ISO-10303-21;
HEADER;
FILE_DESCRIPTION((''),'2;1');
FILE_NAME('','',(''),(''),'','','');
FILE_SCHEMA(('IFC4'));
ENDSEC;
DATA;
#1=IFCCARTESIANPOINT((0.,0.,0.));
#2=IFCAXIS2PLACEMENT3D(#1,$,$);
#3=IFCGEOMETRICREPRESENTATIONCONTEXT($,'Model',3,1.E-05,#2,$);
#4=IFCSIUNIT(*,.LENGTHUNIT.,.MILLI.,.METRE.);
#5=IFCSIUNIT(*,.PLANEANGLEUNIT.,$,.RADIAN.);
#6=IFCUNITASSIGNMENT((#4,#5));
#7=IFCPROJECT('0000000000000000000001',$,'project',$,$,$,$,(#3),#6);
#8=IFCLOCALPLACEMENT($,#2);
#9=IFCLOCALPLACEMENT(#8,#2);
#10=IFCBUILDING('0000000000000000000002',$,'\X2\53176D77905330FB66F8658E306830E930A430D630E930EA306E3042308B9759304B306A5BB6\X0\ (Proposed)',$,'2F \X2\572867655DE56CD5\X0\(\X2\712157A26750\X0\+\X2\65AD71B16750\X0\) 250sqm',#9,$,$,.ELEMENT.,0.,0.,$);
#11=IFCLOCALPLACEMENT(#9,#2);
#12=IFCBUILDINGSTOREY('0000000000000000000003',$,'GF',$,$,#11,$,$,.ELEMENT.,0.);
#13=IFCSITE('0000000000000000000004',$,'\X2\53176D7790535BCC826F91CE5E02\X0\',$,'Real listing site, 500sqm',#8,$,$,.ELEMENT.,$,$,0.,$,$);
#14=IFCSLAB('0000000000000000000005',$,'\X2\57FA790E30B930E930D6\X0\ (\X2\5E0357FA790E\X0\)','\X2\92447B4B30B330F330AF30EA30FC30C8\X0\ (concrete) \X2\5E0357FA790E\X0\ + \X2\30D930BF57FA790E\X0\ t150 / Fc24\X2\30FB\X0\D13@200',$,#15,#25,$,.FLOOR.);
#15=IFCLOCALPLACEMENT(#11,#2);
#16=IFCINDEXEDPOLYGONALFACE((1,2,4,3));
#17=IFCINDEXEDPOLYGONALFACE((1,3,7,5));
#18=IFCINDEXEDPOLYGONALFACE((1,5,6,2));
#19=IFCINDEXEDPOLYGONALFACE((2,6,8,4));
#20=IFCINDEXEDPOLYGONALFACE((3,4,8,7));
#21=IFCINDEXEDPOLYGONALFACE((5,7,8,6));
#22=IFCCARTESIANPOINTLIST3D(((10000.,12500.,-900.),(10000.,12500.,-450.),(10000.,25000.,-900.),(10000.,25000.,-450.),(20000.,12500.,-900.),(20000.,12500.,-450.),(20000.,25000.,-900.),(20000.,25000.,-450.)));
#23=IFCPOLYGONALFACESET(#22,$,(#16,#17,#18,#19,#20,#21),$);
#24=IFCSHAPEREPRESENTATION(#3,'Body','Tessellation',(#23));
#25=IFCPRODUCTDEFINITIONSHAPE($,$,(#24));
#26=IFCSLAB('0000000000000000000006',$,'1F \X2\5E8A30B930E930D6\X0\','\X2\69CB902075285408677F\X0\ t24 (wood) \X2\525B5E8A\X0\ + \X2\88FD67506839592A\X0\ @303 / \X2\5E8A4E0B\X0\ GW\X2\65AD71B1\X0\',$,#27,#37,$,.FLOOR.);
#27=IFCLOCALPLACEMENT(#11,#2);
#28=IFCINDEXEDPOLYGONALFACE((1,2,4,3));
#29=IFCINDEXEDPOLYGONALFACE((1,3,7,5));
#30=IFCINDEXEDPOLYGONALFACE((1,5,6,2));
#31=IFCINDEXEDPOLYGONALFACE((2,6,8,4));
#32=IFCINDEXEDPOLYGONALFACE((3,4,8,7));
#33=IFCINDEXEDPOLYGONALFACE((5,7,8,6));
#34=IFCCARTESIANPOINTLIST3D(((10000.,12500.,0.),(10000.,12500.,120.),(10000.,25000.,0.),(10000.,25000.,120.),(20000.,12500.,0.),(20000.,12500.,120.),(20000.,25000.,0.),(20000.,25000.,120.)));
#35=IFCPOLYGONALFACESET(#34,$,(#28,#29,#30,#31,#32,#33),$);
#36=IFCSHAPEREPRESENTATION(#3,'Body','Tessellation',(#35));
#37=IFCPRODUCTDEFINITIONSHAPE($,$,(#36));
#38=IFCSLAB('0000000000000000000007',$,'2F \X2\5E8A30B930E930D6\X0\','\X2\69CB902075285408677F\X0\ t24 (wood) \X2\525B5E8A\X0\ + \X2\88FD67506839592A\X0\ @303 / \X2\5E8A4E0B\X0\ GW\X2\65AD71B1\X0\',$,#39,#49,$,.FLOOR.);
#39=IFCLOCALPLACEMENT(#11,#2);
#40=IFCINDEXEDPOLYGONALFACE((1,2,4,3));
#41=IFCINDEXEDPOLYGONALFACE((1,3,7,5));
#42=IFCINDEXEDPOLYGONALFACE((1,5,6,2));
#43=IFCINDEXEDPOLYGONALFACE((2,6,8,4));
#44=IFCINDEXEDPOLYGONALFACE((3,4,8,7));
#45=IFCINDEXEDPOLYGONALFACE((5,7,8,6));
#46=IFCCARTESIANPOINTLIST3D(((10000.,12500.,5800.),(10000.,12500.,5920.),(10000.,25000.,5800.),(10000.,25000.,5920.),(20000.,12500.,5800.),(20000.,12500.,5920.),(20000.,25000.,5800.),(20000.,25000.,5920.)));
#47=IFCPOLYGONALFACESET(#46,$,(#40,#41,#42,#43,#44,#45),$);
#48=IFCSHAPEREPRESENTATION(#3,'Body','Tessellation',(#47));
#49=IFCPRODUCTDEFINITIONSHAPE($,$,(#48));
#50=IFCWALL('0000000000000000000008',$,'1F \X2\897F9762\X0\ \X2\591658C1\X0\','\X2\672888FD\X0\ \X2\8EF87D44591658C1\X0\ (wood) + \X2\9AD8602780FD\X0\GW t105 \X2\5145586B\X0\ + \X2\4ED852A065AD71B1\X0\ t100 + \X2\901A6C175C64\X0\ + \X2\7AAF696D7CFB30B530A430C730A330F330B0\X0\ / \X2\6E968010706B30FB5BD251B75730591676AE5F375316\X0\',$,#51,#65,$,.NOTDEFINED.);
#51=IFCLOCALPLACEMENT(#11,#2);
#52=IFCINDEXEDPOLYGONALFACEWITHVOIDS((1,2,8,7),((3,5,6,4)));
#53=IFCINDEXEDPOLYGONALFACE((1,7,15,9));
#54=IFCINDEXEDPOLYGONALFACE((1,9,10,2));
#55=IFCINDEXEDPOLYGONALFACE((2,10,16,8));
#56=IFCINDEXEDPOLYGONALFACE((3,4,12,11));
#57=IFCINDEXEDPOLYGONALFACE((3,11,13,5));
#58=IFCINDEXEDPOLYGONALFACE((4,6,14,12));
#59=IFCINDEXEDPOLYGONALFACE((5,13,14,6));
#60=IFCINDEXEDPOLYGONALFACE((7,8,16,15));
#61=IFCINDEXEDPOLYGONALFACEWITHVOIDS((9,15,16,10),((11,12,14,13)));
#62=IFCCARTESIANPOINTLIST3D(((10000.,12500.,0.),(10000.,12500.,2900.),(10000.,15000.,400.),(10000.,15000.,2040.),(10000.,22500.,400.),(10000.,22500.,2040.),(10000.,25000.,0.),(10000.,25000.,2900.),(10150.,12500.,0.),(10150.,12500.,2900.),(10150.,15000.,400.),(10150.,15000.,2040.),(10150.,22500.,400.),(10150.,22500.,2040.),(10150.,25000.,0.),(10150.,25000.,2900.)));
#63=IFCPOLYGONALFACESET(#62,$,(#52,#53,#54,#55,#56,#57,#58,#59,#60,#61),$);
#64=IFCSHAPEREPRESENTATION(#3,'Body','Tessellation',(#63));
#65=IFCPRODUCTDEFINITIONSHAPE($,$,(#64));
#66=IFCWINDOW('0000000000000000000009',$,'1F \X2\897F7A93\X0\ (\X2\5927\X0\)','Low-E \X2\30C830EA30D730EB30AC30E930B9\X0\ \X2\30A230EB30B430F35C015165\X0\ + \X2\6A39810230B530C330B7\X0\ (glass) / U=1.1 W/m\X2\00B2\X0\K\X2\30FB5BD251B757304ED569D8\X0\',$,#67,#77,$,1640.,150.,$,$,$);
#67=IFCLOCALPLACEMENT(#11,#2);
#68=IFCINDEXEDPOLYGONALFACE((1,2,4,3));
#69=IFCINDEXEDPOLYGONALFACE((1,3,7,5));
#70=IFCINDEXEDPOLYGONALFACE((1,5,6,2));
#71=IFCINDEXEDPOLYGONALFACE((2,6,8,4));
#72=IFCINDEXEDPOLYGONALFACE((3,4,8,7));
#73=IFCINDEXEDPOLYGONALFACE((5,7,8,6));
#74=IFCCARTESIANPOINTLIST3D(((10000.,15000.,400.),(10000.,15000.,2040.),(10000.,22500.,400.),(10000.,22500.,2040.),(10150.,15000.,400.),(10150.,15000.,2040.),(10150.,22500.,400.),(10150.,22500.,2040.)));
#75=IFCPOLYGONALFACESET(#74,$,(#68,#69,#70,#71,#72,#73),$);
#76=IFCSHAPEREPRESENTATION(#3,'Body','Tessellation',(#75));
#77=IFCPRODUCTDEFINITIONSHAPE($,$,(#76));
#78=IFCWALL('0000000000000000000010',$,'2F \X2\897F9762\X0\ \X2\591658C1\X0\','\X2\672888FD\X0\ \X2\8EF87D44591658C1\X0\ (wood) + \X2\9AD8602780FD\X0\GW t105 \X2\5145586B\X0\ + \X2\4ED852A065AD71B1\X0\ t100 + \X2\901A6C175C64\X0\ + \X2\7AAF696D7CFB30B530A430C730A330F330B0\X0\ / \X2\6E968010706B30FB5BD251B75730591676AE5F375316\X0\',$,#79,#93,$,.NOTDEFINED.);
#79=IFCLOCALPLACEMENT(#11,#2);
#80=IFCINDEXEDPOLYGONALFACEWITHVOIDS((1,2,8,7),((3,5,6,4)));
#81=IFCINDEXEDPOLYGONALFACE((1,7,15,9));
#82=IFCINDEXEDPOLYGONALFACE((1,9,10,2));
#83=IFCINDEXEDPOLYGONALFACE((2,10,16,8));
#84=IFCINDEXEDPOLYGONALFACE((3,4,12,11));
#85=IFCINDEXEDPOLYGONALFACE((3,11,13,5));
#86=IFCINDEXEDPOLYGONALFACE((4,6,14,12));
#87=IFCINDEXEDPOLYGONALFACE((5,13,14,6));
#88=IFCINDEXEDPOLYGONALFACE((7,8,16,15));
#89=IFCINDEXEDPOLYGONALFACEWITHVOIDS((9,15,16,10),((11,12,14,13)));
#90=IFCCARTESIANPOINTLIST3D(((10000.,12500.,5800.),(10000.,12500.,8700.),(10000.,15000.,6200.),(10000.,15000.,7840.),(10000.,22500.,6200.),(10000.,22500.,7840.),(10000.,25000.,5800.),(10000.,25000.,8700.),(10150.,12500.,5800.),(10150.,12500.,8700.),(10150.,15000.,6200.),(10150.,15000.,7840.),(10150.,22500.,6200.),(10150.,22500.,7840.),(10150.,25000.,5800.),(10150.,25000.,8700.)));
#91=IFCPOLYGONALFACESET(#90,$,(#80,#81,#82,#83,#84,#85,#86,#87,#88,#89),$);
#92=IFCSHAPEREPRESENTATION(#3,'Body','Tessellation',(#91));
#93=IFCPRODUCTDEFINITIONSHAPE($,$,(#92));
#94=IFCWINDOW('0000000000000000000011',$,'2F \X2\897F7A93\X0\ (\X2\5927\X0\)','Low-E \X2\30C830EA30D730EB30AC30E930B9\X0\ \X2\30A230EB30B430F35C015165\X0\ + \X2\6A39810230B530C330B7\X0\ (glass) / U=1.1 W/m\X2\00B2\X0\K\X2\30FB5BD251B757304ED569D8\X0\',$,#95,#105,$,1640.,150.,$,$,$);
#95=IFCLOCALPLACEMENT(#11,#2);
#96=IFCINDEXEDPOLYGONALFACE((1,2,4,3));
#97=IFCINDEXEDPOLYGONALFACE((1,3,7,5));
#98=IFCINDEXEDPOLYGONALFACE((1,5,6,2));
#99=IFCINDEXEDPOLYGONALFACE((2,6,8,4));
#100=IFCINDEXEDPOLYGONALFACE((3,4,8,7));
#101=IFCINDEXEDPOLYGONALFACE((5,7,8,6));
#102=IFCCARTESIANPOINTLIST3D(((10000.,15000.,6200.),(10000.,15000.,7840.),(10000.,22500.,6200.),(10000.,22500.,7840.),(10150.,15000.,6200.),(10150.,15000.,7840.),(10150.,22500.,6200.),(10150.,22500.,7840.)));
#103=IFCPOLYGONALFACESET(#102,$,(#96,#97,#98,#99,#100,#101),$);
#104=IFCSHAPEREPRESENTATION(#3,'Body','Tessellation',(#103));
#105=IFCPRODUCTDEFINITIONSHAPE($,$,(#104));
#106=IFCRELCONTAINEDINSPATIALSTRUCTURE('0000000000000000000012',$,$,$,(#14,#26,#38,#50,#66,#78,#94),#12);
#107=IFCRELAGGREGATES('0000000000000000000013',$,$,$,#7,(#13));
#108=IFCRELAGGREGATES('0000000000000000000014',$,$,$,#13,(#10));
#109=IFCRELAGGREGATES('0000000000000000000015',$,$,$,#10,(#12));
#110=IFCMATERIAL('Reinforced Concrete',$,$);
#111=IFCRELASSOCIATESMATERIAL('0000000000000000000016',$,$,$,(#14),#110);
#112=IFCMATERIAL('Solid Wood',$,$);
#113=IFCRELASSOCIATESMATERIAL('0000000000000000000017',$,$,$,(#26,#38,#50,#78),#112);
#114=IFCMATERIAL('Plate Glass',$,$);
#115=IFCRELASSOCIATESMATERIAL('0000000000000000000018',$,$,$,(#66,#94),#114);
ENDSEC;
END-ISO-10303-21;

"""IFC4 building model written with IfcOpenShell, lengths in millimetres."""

from ifc_helpers import new_model, si_unit, frame, frame_2d, origin, place, context, project, spatial, rectangle, extrude, material, element, fill, save


model = new_model("IFC4")

# Units and contexts
model_context = context("Model", 3, precision=1e-05, world=origin())
ifc_project = project(units=[si_unit("LENGTHUNIT", "METRE", prefix="MILLI"), si_unit("PLANEANGLEUNIT", "RADIAN")], contexts=[model_context])

# Site, building, storey
site_placement = place(None, origin())
site = spatial("IfcSite", under=ifc_project, at=site_placement, Name="北海道富良野市", ObjectType="Real listing site, 500sqm", CompositionType="ELEMENT", RefElevation=0.0)
building_placement = place(site_placement, origin())
building = spatial("IfcBuilding", under=site, at=building_placement, Name="北海道・書斎とライブラリのある静かな家 (Proposed)", ObjectType="2F 在来工法(無垢材+断熱材) 250sqm", CompositionType="ELEMENT", ElevationOfRefHeight=0.0, ElevationOfTerrain=0.0)
storey_placement = place(building_placement, origin())
storey = spatial("IfcBuildingStorey", under=building, at=storey_placement, Name="GF", CompositionType="ELEMENT", Elevation=0.0)

# Shared definitions
ifc_material_1 = material(Name="Solid Wood")

# Slabs
ifc_material_2 = material(Name="Reinforced Concrete")
slab_1_placement = place(storey_placement, frame((5000.0, 6250.0, -450.0)))
element("IfcSlab", 1, at=slab_1_placement, inside=storey, material=ifc_material_2, Name="基礎スラブ (布基礎)", Description="鉄筋コンクリート (concrete) 布基礎 + ベタ基礎 t150 / Fc24・D13@200", PredefinedType="FLOOR", context=model_context, shape_type="SweptSolid", body=[
    extrude(rectangle(XDim=10000.0, YDim=12500.0, at=frame_2d((5000.0, 6250.0))), frame((5000.0, 6250.0, -450.0)), (0.0, 0.0, 1.0), 450.0),
])
slab_2_placement = place(storey_placement, frame((5000.0, 6250.0, 0.0)))
element("IfcSlab", 2, at=slab_2_placement, inside=storey, material=ifc_material_1, Name="1F 床スラブ", Description="構造用合板 t24 (wood) 剛床 + 製材根太 @303 / 床下 GW断熱", PredefinedType="FLOOR", context=model_context, shape_type="SweptSolid", body=[
    extrude(rectangle(XDim=10000.0, YDim=12500.0, at=frame_2d((5000.0, 6250.0))), frame((5000.0, 6250.0, 0.0)), (0.0, 0.0, 1.0), 120.0),
])
slab_3_placement = place(storey_placement, frame((5000.0, 6250.0, 2900.0)))
element("IfcSlab", 3, at=slab_3_placement, inside=storey, material=ifc_material_1, Name="2F 床スラブ", Description="構造用合板 t24 (wood) 剛床 + 製材根太 @303 / 床下 GW断熱", PredefinedType="FLOOR", context=model_context, shape_type="SweptSolid", body=[
    extrude(rectangle(XDim=10000.0, YDim=12500.0, at=frame_2d((5000.0, 6250.0))), frame((5000.0, 6250.0, 2900.0)), (0.0, 0.0, 1.0), 120.0),
])

# Shared definitions
ifc_material_3 = material(Name="Plate Glass")

# Wall, opening, window
wall_1_placement = place(storey_placement, frame((5000.0, 6250.0, 0.0)))
wall_1 = element("IfcWall", 4, at=wall_1_placement, inside=storey, material=ifc_material_1, Name="1F 西面 外壁", Description="木製 軸組外壁 (wood) + 高性能GW t105 充填 + 付加断熱 t100 + 通気層 + 窯業系サイディング / 準耐火・寒冷地外皮強化", PredefinedType="NOTDEFINED", context=model_context, shape_type="SweptSolid", body=[
    extrude(rectangle(XDim=150.0, YDim=12500.0, at=frame_2d((75.0, 6250.0))), frame((5000.0, 6250.0, 0.0)), (0.0, 0.0, 1.0), 2900.0),
])
opening_1_placement = place(storey_placement, frame((5000.0, 7500.0, 200.0)))
opening_1 = element("IfcOpeningElement", 5, at=opening_1_placement, cuts=wall_1, PredefinedType="NOTDEFINED", context=model_context, shape_type="SweptSolid", body=[
    extrude(rectangle(XDim=150.0, YDim=7500.0, at=frame_2d((75.0, 3750.0))), frame((5000.0, 7500.0, 200.0)), (0.0, 0.0, 1.0), 1640.0),
])
window_1_placement = place(storey_placement, frame((5000.0, 7500.0, 200.0)))
window_1 = element("IfcWindow", 6, at=window_1_placement, inside=storey, material=ifc_material_3, Name="1F 西窓 (大)", Description="Low-E トリプルガラス アルゴン封入 + 樹脂サッシ (glass) / U=1.1 W/m²K・寒冷地仕様", OverallHeight=1640.0, OverallWidth=150.0, context=model_context, shape_type="SweptSolid", body=[
    extrude(rectangle(XDim=150.0, YDim=7500.0, at=frame_2d((75.0, 3750.0))), frame((5000.0, 7500.0, 200.0)), (0.0, 0.0, 1.0), 1640.0),
])
fill(opening_1, window_1)

# Wall, opening, window
wall_2_placement = place(storey_placement, frame((5000.0, 6250.0, 2900.0)))
wall_2 = element("IfcWall", 7, at=wall_2_placement, inside=storey, material=ifc_material_1, Name="2F 西面 外壁", Description="木製 軸組外壁 (wood) + 高性能GW t105 充填 + 付加断熱 t100 + 通気層 + 窯業系サイディング / 準耐火・寒冷地外皮強化", PredefinedType="NOTDEFINED", context=model_context, shape_type="SweptSolid", body=[
    extrude(rectangle(XDim=150.0, YDim=12500.0, at=frame_2d((75.0, 6250.0))), frame((5000.0, 6250.0, 2900.0)), (0.0, 0.0, 1.0), 2900.0),
])
opening_2_placement = place(storey_placement, frame((5000.0, 7500.0, 3100.0)))
opening_2 = element("IfcOpeningElement", 8, at=opening_2_placement, cuts=wall_2, PredefinedType="NOTDEFINED", context=model_context, shape_type="SweptSolid", body=[
    extrude(rectangle(XDim=150.0, YDim=7500.0, at=frame_2d((75.0, 3750.0))), frame((5000.0, 7500.0, 3100.0)), (0.0, 0.0, 1.0), 1640.0),
])
window_2_placement = place(storey_placement, frame((5000.0, 7500.0, 3100.0)))
window_2 = element("IfcWindow", 9, at=window_2_placement, inside=storey, material=ifc_material_3, Name="2F 西窓 (大)", Description="Low-E トリプルガラス アルゴン封入 + 樹脂サッシ (glass) / U=1.1 W/m²K・寒冷地仕様", OverallHeight=1640.0, OverallWidth=150.0, context=model_context, shape_type="SweptSolid", body=[
    extrude(rectangle(XDim=150.0, YDim=7500.0, at=frame_2d((75.0, 3750.0))), frame((5000.0, 7500.0, 3100.0)), (0.0, 0.0, 1.0), 1640.0),
])
fill(opening_2, window_2)

save(model, "model.ifc")
